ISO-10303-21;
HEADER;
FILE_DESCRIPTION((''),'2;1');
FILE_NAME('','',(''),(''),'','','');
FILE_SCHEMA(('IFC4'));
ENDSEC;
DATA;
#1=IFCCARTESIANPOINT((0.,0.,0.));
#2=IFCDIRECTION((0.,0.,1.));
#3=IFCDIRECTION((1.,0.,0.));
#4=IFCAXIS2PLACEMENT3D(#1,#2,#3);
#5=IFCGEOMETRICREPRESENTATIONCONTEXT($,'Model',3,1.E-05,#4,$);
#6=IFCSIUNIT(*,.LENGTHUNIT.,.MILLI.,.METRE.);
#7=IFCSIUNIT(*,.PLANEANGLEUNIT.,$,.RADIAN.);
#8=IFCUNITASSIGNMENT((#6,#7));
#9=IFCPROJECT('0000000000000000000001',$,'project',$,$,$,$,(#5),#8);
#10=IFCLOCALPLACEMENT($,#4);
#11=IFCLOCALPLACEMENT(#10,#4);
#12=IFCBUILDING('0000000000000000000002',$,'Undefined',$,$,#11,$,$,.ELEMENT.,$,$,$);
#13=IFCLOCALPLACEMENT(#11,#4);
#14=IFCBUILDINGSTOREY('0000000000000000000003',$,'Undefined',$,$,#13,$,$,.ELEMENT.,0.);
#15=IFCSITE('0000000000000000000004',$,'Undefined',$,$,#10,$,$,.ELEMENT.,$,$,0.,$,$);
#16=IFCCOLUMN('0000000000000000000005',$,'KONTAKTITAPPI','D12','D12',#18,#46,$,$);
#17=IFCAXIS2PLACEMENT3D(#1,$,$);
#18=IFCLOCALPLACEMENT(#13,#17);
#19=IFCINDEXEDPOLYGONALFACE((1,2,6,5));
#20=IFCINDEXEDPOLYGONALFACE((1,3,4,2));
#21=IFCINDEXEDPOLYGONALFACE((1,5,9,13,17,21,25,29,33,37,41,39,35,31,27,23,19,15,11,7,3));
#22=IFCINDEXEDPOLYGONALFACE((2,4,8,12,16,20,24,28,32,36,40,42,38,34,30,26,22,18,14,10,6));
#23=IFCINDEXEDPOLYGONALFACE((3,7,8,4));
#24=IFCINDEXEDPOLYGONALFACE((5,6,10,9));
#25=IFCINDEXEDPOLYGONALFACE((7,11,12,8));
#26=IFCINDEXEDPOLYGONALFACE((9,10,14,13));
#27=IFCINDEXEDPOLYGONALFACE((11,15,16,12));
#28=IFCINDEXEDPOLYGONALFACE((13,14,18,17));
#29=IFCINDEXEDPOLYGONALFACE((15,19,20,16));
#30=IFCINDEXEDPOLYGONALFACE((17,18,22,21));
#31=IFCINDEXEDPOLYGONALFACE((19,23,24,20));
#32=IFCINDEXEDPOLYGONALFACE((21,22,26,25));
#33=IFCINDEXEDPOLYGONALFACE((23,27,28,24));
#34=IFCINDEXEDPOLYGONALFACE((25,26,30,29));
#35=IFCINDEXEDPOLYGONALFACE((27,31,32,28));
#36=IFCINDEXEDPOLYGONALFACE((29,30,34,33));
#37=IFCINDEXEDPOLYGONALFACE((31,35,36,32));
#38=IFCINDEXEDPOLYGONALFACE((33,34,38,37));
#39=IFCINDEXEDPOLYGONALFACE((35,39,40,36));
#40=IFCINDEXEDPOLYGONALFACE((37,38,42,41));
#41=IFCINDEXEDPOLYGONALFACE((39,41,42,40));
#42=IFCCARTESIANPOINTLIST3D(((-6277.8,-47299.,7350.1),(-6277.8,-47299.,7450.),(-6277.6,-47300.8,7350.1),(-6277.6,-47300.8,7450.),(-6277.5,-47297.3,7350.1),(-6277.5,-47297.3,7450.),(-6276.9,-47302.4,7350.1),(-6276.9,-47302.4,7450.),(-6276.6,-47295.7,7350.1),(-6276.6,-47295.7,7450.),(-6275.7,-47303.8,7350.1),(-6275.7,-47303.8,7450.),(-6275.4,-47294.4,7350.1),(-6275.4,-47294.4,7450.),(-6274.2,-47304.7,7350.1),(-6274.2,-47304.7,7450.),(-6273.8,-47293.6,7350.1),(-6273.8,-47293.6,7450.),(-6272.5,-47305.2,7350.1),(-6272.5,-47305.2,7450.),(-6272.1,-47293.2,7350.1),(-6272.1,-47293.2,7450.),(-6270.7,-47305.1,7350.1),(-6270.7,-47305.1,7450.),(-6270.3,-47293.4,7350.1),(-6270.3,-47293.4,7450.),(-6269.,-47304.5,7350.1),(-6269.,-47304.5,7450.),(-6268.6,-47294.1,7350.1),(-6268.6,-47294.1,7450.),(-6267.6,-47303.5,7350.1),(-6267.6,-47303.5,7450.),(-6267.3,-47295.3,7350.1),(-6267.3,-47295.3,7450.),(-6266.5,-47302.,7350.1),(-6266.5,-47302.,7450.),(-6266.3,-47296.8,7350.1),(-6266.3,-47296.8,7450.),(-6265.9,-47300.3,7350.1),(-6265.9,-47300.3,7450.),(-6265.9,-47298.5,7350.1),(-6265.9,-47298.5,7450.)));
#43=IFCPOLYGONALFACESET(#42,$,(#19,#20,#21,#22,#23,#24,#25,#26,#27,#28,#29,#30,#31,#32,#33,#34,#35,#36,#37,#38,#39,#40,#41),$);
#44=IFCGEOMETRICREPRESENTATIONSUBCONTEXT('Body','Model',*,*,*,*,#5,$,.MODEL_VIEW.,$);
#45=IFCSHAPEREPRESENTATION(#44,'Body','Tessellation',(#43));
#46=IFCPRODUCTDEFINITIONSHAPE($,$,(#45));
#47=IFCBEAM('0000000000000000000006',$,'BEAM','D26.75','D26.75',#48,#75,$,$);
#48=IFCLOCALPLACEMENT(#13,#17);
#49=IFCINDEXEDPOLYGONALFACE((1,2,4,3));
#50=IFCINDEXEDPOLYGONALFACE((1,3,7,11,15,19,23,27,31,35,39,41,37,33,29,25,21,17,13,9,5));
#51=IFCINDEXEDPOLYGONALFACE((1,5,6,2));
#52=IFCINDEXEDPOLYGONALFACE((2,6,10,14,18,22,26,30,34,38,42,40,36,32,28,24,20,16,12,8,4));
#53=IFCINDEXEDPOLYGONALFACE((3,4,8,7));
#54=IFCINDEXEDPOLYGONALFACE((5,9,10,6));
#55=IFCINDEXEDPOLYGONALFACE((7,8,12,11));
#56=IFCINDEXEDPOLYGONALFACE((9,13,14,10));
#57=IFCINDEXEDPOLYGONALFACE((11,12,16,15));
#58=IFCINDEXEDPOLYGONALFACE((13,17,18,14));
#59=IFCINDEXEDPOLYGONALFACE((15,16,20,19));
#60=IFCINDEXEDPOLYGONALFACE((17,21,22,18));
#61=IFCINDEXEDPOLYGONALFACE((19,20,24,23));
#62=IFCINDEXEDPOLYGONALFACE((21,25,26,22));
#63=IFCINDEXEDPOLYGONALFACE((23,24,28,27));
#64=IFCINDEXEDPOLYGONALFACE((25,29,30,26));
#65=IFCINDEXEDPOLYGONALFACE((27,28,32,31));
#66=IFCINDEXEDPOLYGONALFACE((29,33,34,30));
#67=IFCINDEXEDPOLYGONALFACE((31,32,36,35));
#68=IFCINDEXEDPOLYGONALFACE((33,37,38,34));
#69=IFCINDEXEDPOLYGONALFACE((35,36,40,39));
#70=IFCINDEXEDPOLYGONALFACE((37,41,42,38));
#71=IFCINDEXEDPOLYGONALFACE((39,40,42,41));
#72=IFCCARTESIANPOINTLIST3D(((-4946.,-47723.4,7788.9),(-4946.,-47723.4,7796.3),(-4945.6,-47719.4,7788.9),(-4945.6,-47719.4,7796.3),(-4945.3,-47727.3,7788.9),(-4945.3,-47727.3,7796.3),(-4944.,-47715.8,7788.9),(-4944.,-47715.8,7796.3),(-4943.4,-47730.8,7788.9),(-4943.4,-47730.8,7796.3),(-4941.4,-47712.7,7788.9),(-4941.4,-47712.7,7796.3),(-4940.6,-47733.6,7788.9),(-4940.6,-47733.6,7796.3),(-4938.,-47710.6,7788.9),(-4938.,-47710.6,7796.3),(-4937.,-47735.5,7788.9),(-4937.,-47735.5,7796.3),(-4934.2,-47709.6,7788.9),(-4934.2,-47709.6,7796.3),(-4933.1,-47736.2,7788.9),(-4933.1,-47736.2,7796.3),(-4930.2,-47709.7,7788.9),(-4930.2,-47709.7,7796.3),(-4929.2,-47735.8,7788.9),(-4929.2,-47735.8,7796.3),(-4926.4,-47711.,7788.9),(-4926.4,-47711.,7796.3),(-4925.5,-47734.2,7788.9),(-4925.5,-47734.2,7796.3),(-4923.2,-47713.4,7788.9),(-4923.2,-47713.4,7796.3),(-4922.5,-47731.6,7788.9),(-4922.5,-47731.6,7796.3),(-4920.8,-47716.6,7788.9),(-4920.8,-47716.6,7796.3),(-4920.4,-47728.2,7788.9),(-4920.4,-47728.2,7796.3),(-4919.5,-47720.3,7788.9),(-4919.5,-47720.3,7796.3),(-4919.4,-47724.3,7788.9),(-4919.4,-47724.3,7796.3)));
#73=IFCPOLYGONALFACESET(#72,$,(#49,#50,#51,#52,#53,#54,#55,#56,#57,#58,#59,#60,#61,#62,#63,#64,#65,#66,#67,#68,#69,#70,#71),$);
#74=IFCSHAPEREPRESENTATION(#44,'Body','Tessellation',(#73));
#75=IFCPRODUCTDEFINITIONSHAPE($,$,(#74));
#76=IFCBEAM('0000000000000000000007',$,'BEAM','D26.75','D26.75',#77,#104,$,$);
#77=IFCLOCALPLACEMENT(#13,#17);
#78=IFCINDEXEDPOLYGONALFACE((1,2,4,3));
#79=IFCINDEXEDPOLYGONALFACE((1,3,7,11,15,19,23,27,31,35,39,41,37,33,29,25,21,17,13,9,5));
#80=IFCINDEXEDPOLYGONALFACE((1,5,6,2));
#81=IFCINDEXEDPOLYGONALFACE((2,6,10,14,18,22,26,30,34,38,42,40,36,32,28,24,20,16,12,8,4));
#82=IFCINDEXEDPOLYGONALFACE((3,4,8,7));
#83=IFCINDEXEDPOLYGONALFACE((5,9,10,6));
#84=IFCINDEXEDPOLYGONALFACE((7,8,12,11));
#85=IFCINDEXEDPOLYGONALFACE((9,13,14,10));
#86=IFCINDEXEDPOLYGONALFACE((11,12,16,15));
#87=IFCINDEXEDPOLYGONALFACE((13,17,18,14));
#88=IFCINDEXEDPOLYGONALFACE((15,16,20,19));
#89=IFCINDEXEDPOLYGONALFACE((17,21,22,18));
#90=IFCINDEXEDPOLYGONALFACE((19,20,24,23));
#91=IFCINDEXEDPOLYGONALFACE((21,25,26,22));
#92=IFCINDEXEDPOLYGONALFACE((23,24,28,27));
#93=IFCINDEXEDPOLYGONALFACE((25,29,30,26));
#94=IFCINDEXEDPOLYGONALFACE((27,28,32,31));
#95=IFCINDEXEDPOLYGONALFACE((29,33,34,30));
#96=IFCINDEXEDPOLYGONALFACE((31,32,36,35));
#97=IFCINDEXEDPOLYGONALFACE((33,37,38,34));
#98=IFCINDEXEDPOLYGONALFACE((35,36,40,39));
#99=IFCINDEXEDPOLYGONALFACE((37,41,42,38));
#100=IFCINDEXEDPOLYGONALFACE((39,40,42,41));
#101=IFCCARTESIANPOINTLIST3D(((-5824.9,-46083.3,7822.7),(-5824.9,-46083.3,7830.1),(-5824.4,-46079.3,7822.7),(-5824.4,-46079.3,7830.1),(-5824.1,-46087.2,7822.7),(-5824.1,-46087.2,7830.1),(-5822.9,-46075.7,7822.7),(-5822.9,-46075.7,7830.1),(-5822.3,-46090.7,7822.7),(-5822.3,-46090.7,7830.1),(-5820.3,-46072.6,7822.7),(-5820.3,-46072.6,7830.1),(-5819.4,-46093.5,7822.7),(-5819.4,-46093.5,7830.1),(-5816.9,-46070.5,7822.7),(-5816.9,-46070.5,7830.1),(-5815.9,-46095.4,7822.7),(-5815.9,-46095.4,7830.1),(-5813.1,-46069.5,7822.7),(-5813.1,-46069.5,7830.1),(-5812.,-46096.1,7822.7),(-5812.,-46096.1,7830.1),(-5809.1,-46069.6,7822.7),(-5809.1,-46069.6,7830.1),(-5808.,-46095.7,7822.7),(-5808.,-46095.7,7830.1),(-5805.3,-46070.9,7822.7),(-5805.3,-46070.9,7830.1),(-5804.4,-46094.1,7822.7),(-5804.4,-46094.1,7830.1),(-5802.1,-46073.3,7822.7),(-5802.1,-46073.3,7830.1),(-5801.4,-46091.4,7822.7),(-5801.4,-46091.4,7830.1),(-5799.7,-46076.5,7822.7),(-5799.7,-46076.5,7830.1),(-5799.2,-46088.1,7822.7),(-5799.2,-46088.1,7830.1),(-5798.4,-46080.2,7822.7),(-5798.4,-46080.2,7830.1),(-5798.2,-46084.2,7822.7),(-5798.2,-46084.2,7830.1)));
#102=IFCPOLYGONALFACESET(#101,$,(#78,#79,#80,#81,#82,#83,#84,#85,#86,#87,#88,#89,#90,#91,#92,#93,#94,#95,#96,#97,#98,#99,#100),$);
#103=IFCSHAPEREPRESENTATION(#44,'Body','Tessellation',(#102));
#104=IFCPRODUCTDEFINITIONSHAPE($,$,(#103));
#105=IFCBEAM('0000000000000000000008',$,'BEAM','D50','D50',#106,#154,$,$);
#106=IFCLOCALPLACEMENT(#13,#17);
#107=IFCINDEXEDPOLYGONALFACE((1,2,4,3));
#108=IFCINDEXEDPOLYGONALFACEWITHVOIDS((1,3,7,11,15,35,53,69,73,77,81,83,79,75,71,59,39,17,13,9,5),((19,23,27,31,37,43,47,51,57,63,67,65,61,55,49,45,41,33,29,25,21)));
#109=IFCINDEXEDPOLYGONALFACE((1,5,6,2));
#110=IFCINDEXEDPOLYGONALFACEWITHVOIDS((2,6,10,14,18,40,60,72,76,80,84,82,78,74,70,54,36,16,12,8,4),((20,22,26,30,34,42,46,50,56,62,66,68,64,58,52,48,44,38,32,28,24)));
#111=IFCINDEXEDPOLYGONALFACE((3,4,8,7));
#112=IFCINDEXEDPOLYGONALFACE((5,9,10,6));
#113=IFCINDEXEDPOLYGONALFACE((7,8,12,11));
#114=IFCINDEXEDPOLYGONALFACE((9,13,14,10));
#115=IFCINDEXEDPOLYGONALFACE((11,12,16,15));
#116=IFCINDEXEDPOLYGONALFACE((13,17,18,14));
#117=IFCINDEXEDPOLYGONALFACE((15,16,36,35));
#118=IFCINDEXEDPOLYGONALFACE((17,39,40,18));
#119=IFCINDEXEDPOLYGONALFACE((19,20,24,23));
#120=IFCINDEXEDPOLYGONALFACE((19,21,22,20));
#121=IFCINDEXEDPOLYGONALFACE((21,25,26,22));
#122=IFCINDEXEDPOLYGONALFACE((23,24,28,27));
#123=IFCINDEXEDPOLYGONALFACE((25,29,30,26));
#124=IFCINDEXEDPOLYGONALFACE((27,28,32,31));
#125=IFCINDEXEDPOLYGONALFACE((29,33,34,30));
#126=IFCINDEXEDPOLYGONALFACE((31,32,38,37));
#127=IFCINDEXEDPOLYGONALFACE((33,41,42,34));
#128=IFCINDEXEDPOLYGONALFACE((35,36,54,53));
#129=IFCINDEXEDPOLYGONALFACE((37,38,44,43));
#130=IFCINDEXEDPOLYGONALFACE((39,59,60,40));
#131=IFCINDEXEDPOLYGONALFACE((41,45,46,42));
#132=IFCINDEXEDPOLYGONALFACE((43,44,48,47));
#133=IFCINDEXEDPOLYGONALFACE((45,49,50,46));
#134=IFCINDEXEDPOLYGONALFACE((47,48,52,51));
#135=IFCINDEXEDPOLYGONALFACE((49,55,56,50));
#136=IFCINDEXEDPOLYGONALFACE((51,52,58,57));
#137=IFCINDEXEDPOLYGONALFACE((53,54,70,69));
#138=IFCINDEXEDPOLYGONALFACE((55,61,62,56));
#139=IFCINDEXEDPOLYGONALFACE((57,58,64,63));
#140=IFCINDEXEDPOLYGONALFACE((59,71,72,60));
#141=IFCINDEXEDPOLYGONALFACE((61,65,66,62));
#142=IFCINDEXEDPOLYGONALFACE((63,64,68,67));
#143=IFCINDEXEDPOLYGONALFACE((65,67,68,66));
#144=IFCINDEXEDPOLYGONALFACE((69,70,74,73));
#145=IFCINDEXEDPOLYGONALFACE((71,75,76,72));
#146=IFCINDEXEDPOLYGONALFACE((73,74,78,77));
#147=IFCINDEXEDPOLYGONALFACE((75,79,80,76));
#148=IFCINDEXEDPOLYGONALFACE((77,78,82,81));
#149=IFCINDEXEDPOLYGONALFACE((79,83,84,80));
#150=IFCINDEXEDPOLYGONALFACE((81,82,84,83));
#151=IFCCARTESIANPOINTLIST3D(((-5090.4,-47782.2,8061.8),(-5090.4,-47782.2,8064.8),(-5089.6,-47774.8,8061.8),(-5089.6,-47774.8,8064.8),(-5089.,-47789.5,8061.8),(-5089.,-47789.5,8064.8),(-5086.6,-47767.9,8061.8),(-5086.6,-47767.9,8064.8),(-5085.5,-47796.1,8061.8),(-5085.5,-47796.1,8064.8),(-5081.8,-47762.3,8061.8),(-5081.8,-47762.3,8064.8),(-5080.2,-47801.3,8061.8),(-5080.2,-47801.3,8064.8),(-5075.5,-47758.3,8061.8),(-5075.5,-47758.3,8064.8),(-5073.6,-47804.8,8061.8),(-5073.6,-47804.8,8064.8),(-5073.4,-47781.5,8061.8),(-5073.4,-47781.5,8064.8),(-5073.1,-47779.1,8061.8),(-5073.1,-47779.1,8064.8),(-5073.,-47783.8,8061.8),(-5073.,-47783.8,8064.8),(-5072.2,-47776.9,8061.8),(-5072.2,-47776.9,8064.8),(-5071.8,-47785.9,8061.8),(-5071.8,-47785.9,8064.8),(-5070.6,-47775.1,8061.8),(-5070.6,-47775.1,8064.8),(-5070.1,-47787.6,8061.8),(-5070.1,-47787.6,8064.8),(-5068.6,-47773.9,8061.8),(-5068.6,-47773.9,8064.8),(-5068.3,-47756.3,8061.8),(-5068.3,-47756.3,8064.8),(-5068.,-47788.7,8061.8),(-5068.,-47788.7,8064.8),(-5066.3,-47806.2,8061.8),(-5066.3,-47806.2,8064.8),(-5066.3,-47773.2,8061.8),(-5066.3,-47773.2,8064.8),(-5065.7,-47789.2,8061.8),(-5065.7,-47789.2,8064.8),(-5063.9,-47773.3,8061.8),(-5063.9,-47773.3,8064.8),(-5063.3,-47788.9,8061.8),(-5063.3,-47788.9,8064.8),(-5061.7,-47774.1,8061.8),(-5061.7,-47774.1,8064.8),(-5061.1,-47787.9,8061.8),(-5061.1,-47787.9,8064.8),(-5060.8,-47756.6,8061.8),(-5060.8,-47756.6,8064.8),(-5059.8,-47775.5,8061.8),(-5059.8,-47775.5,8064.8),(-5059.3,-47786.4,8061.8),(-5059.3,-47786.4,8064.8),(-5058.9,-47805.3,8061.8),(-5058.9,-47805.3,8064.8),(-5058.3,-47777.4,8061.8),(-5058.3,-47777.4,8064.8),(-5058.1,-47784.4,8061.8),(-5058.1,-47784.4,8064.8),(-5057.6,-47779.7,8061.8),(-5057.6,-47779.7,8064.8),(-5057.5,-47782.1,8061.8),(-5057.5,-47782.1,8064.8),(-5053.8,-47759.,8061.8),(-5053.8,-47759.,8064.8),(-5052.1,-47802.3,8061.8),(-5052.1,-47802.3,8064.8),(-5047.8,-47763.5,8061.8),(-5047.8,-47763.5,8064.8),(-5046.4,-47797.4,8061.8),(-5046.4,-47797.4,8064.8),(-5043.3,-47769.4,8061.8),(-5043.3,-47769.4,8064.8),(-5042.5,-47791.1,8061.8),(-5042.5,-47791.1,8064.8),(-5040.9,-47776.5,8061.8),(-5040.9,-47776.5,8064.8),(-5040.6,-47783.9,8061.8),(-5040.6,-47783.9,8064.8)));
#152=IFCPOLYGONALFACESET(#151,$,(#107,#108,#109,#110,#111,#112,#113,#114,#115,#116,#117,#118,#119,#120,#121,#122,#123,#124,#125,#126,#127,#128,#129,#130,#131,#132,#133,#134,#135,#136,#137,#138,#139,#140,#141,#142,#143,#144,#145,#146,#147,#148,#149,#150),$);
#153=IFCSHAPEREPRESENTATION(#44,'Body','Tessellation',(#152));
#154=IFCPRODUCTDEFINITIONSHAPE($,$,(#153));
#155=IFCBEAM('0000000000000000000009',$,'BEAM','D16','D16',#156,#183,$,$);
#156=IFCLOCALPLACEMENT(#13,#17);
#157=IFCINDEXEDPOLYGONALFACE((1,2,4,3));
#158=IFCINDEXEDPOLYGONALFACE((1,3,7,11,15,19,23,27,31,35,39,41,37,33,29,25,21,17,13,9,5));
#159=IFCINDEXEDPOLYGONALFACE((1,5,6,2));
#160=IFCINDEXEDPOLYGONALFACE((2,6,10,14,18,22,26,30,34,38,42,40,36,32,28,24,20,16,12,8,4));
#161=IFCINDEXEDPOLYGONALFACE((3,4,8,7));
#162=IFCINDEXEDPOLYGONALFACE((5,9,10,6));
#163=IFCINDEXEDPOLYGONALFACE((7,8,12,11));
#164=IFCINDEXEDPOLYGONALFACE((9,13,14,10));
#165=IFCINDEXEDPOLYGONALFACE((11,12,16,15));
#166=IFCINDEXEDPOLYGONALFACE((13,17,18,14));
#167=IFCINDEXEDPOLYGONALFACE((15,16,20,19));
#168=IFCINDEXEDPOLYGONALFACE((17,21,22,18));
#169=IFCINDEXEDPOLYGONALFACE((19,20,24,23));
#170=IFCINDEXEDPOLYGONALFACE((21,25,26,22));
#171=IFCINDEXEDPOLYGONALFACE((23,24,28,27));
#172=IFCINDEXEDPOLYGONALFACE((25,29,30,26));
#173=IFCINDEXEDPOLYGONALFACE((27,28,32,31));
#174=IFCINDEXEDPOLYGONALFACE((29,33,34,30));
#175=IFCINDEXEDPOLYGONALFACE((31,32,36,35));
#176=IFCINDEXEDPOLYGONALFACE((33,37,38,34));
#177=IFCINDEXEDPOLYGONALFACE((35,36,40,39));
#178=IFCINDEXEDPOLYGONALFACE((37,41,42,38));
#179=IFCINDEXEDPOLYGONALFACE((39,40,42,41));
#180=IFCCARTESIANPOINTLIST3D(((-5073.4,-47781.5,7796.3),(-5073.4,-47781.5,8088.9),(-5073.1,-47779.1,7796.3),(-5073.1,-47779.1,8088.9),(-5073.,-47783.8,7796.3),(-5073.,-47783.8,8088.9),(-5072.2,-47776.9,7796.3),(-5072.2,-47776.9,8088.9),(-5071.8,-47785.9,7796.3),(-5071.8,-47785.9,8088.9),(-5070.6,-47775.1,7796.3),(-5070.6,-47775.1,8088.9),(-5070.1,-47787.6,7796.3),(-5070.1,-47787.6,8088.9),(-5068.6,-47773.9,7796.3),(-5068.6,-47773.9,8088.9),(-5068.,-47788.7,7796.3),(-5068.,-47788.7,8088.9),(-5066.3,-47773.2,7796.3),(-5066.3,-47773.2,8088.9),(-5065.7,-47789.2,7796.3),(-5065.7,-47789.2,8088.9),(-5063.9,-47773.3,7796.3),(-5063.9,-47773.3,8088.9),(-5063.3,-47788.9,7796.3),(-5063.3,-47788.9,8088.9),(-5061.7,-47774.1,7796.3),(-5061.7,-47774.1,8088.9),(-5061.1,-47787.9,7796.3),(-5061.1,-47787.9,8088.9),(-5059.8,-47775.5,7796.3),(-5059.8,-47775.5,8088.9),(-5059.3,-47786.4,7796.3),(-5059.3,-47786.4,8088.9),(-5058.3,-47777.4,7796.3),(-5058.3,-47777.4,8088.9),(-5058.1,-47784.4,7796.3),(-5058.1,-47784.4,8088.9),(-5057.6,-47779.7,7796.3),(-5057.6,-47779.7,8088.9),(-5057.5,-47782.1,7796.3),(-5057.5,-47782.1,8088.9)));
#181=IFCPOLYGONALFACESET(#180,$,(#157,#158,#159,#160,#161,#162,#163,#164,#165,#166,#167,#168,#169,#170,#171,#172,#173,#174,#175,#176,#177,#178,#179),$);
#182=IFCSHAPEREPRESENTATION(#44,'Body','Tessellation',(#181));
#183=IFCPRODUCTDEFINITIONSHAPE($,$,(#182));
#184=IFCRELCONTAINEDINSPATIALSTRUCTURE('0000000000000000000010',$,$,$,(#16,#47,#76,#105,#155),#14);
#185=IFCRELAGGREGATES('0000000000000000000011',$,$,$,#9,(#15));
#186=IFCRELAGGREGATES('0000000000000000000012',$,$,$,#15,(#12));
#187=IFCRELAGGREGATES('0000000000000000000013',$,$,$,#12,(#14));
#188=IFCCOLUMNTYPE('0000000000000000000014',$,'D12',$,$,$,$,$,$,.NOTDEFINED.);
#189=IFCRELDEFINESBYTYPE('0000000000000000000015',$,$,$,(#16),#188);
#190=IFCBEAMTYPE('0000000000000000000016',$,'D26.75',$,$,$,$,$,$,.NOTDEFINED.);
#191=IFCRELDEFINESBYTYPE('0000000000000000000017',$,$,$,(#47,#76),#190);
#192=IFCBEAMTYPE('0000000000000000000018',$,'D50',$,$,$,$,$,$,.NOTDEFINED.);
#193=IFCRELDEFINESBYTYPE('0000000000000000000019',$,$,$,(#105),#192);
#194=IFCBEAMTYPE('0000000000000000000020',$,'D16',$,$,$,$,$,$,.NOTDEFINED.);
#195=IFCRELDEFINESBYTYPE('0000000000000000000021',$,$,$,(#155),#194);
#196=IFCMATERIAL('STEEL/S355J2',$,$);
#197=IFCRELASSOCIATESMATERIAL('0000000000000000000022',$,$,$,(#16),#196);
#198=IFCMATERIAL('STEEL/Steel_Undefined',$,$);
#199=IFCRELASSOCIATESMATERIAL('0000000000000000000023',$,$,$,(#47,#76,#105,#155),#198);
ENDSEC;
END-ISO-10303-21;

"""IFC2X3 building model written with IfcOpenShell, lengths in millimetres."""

from ifc_helpers import new_model, si_unit, frame, origin_with_axes, origin_2d_with_axis, place, context, subcontext, project, spatial, circle, extrude, material, type_object, element, save


model = new_model("IFC2X3")

# Units and contexts
model_context = context("Model", 3, precision=1e-05, world=origin_with_axes())
body_context = subcontext(model_context, "Body", "Model", "MODEL_VIEW")
ifc_project = project(units=[si_unit("LENGTHUNIT", "METRE", prefix="MILLI"), si_unit("PLANEANGLEUNIT", "RADIAN")], contexts=[model_context])

# Site, building, storey
site_placement = place(None, origin_with_axes())
site = spatial("IfcSite", under=ifc_project, at=site_placement, Name="Undefined", CompositionType="ELEMENT", RefElevation=0.0)
building_placement = place(site_placement, origin_with_axes())
building = spatial("IfcBuilding", under=site, at=building_placement, Name="Undefined", CompositionType="ELEMENT")
storey_placement = place(building_placement, origin_with_axes())
storey = spatial("IfcBuildingStorey", under=building, at=storey_placement, Name="Undefined", CompositionType="ELEMENT", Elevation=0.0)

# Column
ifc_material_1 = material(Name="STEEL/S355J2")
column_type = type_object("IfcColumnType", Name="D12", PredefinedType="NOTDEFINED")
column_placement = place(storey_placement, frame((-6271.8, -47299.2, 7350.1), z_axis=(0.0, 0.0, 1.0), x_axis=(1.0, 0.0, 0.0)))
element("IfcColumn", 1, at=column_placement, inside=storey, type_object=column_type, material=ifc_material_1, Name="KONTAKTITAPPI", Description="D12", ObjectType="D12", context=body_context, shape_type="SweptSolid", body=[
    extrude(circle(Radius=6.0, at=origin_2d_with_axis()), frame((0.0, 0.0, 99.9), z_axis=(0.0, 0.0, -1.0), x_axis=(0.915553, 0.402197, 0.0)), (0.0, 0.0, 1.0), 99.9),
])

# Shared definitions
ifc_material_2 = material(Name="STEEL/Steel_Undefined")
beam_type_1 = type_object("IfcBeamType", Name="D26.75", PredefinedType="NOTDEFINED")

# Beam
beam_1_placement = place(storey_placement, frame((-4932.7, -47722.9, 7796.3), z_axis=(-0.915553, -0.402198, 0.0), x_axis=(0.0, 0.0, -1.0)))
element("IfcBeam", 2, at=beam_1_placement, inside=storey, type_object=beam_type_1, material=ifc_material_2, Name="BEAM", Description="D26.75", ObjectType="D26.75", context=body_context, shape_type="SweptSolid", body=[
    extrude(circle(Radius=13.4, at=origin_2d_with_axis()), frame((7.4, 0.0, 0.0), z_axis=(-1.0, 0.0, 0.0), x_axis=(0.0, -1.0, 0.0)), (0.0, 0.0, 1.0), 7.4),
])

# Beam
beam_2_placement = place(storey_placement, frame((-5811.5, -46082.7, 7830.1), z_axis=(-0.915553, -0.402198, 0.0), x_axis=(0.0, 0.0, -1.0)))
element("IfcBeam", 3, at=beam_2_placement, inside=storey, type_object=beam_type_1, material=ifc_material_2, Name="BEAM", Description="D26.75", ObjectType="D26.75", context=body_context, shape_type="SweptSolid", body=[
    extrude(circle(Radius=13.4, at=origin_2d_with_axis()), frame((7.4, 0.0, 0.0), z_axis=(-1.0, 0.0, 0.0), x_axis=(0.0, -1.0, 0.0)), (0.0, 0.0, 1.0), 7.4),
])

# Beam, opening
beam_type_2 = type_object("IfcBeamType", Name="D50", PredefinedType="NOTDEFINED")
beam_3_placement = place(storey_placement, frame((-5065.4, -47781.2, 8064.8), z_axis=(-0.915553, -0.402198, 0.0), x_axis=(0.0, 0.0, -1.0)))
beam_3 = element("IfcBeam", 4, at=beam_3_placement, inside=storey, type_object=beam_type_2, material=ifc_material_2, Name="BEAM", Description="D50", ObjectType="D50", context=body_context, shape_type="SweptSolid", body=[
    extrude(circle(Radius=25.0, at=origin_2d_with_axis()), frame((3.0, 0.0, 0.0), z_axis=(-1.0, 0.0, 0.0), x_axis=(0.0, -1.0, 0.0)), (0.0, 0.0, 1.0), 3.0),
])
opening_1_placement = place(storey_placement, frame((-5065.4, -47781.2, 8064.8), z_axis=(-0.915553, -0.402198, 0.0), x_axis=(0.0, 0.0, -1.0)))
element("IfcOpeningElement", 5, at=opening_1_placement, cuts=beam_3, ObjectType="Recess", context=body_context, shape_type="SweptSolid", body=[
    extrude(circle(Radius=8.0, at=origin_2d_with_axis()), frame((268.5, 0.0, 0.0), z_axis=(-1.0, 0.0, 0.0), x_axis=(0.0, -1.0, 0.0)), (0.0, 0.0, 1.0), 292.6),
])

# Beam
beam_type_3 = type_object("IfcBeamType", Name="D16", PredefinedType="NOTDEFINED")
for number, where, z_axis, x_axis, name in (
    (6, (-5065.4, -47781.2, 8088.9), (-0.915553, -0.402198, 0.0), (0.0, 0.0, -1.0), "BEAM"),
):
    element("IfcBeam", number, at=place(storey_placement, frame(where, z_axis=z_axis, x_axis=x_axis)), inside=storey, type_object=beam_type_3, material=ifc_material_2, Name=name, Description="D16", ObjectType="D16", context=body_context, shape_type="SweptSolid", body=[
        extrude(circle(Radius=8.0, at=origin_2d_with_axis()), frame((292.6, 0.0, 0.0), z_axis=(-1.0, 0.0, 0.0), x_axis=(0.0, -1.0, 0.0)), (0.0, 0.0, 1.0), 292.6),
    ])

save(model, "model.ifc")
